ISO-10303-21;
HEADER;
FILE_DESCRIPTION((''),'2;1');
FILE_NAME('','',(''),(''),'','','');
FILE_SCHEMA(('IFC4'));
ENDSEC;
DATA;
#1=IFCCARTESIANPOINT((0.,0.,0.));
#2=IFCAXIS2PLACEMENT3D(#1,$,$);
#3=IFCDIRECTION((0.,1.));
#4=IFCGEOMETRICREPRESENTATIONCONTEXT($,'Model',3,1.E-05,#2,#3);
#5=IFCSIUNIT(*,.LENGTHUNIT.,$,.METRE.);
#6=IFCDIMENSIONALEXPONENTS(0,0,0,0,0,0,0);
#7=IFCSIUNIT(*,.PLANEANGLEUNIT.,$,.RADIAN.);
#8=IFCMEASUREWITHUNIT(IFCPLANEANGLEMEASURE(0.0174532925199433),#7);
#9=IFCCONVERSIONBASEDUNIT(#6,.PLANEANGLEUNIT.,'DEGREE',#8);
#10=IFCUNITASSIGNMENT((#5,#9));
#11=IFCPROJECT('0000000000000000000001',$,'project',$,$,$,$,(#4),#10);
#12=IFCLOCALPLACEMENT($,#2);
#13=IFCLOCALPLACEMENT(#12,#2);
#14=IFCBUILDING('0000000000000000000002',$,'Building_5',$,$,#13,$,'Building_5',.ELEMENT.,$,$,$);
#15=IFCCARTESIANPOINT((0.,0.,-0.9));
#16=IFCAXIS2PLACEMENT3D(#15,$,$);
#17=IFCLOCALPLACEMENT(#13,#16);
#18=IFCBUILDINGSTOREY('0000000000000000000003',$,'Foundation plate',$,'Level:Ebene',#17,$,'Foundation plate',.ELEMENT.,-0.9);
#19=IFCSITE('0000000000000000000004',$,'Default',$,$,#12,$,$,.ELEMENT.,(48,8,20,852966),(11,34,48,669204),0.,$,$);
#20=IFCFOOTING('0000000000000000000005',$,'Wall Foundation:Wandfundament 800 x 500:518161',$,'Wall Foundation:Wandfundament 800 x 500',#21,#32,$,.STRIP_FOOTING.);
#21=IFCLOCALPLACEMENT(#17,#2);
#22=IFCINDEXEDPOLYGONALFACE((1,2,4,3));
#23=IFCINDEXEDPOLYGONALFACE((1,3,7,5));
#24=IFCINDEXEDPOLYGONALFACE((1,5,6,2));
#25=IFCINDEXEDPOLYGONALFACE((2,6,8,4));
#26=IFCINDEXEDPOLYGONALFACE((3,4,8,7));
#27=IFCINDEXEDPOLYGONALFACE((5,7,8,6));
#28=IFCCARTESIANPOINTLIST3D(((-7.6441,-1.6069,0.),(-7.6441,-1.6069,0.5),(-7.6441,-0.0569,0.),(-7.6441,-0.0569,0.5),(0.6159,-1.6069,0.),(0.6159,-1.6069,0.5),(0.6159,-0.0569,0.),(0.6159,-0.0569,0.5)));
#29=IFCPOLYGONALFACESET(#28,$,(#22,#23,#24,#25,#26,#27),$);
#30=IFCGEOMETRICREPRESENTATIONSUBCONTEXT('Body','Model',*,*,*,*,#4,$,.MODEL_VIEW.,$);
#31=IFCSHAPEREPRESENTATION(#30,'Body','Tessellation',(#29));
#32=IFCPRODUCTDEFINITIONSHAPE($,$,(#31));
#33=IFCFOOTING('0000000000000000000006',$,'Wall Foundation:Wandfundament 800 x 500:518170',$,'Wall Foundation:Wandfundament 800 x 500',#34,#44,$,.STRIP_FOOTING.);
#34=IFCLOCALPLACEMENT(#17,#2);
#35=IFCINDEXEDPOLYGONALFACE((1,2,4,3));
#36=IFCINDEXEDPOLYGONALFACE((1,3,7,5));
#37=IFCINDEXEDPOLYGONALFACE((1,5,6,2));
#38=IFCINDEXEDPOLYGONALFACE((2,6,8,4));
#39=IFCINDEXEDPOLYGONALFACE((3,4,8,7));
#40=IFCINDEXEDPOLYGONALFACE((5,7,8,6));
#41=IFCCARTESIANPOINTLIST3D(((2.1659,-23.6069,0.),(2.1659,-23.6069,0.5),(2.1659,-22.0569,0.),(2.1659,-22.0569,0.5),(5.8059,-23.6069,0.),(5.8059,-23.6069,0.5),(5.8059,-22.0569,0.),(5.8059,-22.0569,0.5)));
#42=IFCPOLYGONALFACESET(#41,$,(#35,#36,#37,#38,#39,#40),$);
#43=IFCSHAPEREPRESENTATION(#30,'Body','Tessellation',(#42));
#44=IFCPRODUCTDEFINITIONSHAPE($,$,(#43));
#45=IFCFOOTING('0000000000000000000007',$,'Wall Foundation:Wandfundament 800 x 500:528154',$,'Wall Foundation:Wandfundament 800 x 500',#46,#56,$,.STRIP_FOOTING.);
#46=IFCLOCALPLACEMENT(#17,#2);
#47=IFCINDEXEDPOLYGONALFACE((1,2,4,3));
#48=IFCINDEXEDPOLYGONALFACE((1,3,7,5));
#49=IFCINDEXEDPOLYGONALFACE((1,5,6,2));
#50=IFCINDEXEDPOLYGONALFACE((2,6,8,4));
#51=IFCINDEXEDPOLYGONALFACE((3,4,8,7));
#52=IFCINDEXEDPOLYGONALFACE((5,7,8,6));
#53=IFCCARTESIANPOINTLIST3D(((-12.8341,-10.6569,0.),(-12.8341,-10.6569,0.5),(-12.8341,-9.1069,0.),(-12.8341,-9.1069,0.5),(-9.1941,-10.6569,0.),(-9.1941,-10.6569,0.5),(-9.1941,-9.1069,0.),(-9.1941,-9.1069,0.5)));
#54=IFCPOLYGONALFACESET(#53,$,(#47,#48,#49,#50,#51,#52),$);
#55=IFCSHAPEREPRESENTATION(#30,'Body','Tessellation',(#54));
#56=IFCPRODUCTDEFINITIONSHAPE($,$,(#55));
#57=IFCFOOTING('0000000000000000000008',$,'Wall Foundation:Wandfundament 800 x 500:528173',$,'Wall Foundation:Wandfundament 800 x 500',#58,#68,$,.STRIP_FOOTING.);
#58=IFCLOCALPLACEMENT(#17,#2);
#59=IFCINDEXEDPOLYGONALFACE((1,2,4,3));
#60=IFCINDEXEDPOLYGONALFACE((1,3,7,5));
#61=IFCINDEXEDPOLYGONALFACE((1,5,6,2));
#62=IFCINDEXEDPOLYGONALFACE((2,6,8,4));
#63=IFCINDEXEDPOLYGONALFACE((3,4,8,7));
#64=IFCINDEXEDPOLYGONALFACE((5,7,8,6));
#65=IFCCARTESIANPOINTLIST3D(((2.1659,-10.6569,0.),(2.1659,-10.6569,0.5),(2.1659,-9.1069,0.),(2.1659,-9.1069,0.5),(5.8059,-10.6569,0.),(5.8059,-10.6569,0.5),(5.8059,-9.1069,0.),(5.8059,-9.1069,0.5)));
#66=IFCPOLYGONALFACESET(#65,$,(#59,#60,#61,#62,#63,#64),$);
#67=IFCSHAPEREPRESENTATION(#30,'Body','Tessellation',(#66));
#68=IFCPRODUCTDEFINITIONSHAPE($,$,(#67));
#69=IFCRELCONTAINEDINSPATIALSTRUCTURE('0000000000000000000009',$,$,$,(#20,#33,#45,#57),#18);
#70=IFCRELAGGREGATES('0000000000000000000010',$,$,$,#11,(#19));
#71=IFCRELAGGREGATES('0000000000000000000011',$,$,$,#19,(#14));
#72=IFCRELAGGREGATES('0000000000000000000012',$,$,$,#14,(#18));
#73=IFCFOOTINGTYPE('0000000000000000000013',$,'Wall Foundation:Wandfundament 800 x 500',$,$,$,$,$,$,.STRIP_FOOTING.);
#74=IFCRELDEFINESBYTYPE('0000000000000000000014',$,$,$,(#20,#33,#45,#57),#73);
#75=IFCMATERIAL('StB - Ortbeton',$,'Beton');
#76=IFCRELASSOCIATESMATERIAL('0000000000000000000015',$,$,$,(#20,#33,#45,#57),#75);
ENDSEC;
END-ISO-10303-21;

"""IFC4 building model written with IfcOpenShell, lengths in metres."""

from ifc_helpers import new_model, entity, si_unit, converted_unit, direction, frame, origin, place, context, subcontext, project, spatial, indexed_curve, outline, extrude, material, type_object, element, save


model = new_model("IFC4")

# Units and contexts
model_context = context("Model", 3, precision=1e-05, world=origin(), true_north=direction((0.0, 1.0)))
body_context = subcontext(model_context, "Body", "Model", "MODEL_VIEW")
ifc_project = project(units=[si_unit("LENGTHUNIT", "METRE"), converted_unit("PLANEANGLEUNIT", "DEGREE", entity("IfcPlaneAngleMeasure", 0.0174532925199433), si_unit("PLANEANGLEUNIT", "RADIAN"), dimensions=[0, 0, 0, 0, 0, 0, 0])], contexts=[model_context])

# Site, building, storey
site_placement = place(None, origin())
site = spatial("IfcSite", under=ifc_project, at=site_placement, Name="Default", CompositionType="ELEMENT", RefLatitude=(48, 8, 20, 852966), RefLongitude=(11, 34, 48, 669204), RefElevation=0.0)
building_placement = place(site_placement, origin())
building = spatial("IfcBuilding", under=site, at=building_placement, Name="Building_5", LongName="Building_5", CompositionType="ELEMENT")
storey_placement = place(building_placement, frame((0.0, 0.0, -0.9)))
storey = spatial("IfcBuildingStorey", under=building, at=storey_placement, Name="Foundation plate", ObjectType="Level:Ebene", LongName="Foundation plate", CompositionType="ELEMENT", Elevation=-0.9)

# Footings
ifc_material = material(Name="StB - Ortbeton", Category="Beton")
footing_type = type_object("IfcFootingType", Name="Wall Foundation:Wandfundament 800 x 500", PredefinedType="STRIP_FOOTING")
footing_1_placement = place(storey_placement, origin())
element("IfcFooting", 1, at=footing_1_placement, inside=storey, type_object=footing_type, material=ifc_material, Name="Wall Foundation:Wandfundament 800 x 500:518161", ObjectType="Wall Foundation:Wandfundament 800 x 500", PredefinedType="STRIP_FOOTING", context=body_context, shape_type="SweptSolid", body=[
    extrude(outline(indexed_curve([(-4.13, -0.775), (4.13, -0.775), (4.13, 0.775), (-4.13, 0.775), (-4.13, -0.775)], self_intersect=False)), frame((-3.5141, -0.8319, 0.0)), (0.0, 0.0, 1.0), 0.5),
])
footing_2_placement = place(storey_placement, origin())
element("IfcFooting", 2, at=footing_2_placement, inside=storey, type_object=footing_type, material=ifc_material, Name="Wall Foundation:Wandfundament 800 x 500:518170", ObjectType="Wall Foundation:Wandfundament 800 x 500", PredefinedType="STRIP_FOOTING", context=body_context, shape_type="SweptSolid", body=[
    extrude(outline(indexed_curve([(-1.82, -0.775), (1.82, -0.775), (1.82, 0.775), (-1.82, 0.775), (-1.82, -0.775)], self_intersect=False)), frame((3.9859, -22.8319, 0.0), z_axis=(0.0, 0.0, 1.0), x_axis=(-1.0, 0.0, 0.0)), (0.0, 0.0, 1.0), 0.5),
])
footing_3_placement = place(storey_placement, origin())
element("IfcFooting", 3, at=footing_3_placement, inside=storey, type_object=footing_type, material=ifc_material, Name="Wall Foundation:Wandfundament 800 x 500:528154", ObjectType="Wall Foundation:Wandfundament 800 x 500", PredefinedType="STRIP_FOOTING", context=body_context, shape_type="SweptSolid", body=[
    extrude(outline(indexed_curve([(-1.82, -0.775), (1.82, -0.775), (1.82, 0.775), (-1.82, 0.775), (-1.82, -0.775)], self_intersect=False)), frame((-11.0141, -9.8819, 0.0)), (0.0, 0.0, 1.0), 0.5),
])
footing_4_placement = place(storey_placement, origin())
element("IfcFooting", 4, at=footing_4_placement, inside=storey, type_object=footing_type, material=ifc_material, Name="Wall Foundation:Wandfundament 800 x 500:528173", ObjectType="Wall Foundation:Wandfundament 800 x 500", PredefinedType="STRIP_FOOTING", context=body_context, shape_type="SweptSolid", body=[
    extrude(outline(indexed_curve([(-1.82, -0.775), (1.82, -0.775), (1.82, 0.775), (-1.82, 0.775), (-1.82, -0.775)], self_intersect=False)), frame((3.9859, -9.8819, 0.0), z_axis=(0.0, 0.0, 1.0), x_axis=(-1.0, 0.0, 0.0)), (0.0, 0.0, 1.0), 0.5),
])

save(model, "model.ifc")
